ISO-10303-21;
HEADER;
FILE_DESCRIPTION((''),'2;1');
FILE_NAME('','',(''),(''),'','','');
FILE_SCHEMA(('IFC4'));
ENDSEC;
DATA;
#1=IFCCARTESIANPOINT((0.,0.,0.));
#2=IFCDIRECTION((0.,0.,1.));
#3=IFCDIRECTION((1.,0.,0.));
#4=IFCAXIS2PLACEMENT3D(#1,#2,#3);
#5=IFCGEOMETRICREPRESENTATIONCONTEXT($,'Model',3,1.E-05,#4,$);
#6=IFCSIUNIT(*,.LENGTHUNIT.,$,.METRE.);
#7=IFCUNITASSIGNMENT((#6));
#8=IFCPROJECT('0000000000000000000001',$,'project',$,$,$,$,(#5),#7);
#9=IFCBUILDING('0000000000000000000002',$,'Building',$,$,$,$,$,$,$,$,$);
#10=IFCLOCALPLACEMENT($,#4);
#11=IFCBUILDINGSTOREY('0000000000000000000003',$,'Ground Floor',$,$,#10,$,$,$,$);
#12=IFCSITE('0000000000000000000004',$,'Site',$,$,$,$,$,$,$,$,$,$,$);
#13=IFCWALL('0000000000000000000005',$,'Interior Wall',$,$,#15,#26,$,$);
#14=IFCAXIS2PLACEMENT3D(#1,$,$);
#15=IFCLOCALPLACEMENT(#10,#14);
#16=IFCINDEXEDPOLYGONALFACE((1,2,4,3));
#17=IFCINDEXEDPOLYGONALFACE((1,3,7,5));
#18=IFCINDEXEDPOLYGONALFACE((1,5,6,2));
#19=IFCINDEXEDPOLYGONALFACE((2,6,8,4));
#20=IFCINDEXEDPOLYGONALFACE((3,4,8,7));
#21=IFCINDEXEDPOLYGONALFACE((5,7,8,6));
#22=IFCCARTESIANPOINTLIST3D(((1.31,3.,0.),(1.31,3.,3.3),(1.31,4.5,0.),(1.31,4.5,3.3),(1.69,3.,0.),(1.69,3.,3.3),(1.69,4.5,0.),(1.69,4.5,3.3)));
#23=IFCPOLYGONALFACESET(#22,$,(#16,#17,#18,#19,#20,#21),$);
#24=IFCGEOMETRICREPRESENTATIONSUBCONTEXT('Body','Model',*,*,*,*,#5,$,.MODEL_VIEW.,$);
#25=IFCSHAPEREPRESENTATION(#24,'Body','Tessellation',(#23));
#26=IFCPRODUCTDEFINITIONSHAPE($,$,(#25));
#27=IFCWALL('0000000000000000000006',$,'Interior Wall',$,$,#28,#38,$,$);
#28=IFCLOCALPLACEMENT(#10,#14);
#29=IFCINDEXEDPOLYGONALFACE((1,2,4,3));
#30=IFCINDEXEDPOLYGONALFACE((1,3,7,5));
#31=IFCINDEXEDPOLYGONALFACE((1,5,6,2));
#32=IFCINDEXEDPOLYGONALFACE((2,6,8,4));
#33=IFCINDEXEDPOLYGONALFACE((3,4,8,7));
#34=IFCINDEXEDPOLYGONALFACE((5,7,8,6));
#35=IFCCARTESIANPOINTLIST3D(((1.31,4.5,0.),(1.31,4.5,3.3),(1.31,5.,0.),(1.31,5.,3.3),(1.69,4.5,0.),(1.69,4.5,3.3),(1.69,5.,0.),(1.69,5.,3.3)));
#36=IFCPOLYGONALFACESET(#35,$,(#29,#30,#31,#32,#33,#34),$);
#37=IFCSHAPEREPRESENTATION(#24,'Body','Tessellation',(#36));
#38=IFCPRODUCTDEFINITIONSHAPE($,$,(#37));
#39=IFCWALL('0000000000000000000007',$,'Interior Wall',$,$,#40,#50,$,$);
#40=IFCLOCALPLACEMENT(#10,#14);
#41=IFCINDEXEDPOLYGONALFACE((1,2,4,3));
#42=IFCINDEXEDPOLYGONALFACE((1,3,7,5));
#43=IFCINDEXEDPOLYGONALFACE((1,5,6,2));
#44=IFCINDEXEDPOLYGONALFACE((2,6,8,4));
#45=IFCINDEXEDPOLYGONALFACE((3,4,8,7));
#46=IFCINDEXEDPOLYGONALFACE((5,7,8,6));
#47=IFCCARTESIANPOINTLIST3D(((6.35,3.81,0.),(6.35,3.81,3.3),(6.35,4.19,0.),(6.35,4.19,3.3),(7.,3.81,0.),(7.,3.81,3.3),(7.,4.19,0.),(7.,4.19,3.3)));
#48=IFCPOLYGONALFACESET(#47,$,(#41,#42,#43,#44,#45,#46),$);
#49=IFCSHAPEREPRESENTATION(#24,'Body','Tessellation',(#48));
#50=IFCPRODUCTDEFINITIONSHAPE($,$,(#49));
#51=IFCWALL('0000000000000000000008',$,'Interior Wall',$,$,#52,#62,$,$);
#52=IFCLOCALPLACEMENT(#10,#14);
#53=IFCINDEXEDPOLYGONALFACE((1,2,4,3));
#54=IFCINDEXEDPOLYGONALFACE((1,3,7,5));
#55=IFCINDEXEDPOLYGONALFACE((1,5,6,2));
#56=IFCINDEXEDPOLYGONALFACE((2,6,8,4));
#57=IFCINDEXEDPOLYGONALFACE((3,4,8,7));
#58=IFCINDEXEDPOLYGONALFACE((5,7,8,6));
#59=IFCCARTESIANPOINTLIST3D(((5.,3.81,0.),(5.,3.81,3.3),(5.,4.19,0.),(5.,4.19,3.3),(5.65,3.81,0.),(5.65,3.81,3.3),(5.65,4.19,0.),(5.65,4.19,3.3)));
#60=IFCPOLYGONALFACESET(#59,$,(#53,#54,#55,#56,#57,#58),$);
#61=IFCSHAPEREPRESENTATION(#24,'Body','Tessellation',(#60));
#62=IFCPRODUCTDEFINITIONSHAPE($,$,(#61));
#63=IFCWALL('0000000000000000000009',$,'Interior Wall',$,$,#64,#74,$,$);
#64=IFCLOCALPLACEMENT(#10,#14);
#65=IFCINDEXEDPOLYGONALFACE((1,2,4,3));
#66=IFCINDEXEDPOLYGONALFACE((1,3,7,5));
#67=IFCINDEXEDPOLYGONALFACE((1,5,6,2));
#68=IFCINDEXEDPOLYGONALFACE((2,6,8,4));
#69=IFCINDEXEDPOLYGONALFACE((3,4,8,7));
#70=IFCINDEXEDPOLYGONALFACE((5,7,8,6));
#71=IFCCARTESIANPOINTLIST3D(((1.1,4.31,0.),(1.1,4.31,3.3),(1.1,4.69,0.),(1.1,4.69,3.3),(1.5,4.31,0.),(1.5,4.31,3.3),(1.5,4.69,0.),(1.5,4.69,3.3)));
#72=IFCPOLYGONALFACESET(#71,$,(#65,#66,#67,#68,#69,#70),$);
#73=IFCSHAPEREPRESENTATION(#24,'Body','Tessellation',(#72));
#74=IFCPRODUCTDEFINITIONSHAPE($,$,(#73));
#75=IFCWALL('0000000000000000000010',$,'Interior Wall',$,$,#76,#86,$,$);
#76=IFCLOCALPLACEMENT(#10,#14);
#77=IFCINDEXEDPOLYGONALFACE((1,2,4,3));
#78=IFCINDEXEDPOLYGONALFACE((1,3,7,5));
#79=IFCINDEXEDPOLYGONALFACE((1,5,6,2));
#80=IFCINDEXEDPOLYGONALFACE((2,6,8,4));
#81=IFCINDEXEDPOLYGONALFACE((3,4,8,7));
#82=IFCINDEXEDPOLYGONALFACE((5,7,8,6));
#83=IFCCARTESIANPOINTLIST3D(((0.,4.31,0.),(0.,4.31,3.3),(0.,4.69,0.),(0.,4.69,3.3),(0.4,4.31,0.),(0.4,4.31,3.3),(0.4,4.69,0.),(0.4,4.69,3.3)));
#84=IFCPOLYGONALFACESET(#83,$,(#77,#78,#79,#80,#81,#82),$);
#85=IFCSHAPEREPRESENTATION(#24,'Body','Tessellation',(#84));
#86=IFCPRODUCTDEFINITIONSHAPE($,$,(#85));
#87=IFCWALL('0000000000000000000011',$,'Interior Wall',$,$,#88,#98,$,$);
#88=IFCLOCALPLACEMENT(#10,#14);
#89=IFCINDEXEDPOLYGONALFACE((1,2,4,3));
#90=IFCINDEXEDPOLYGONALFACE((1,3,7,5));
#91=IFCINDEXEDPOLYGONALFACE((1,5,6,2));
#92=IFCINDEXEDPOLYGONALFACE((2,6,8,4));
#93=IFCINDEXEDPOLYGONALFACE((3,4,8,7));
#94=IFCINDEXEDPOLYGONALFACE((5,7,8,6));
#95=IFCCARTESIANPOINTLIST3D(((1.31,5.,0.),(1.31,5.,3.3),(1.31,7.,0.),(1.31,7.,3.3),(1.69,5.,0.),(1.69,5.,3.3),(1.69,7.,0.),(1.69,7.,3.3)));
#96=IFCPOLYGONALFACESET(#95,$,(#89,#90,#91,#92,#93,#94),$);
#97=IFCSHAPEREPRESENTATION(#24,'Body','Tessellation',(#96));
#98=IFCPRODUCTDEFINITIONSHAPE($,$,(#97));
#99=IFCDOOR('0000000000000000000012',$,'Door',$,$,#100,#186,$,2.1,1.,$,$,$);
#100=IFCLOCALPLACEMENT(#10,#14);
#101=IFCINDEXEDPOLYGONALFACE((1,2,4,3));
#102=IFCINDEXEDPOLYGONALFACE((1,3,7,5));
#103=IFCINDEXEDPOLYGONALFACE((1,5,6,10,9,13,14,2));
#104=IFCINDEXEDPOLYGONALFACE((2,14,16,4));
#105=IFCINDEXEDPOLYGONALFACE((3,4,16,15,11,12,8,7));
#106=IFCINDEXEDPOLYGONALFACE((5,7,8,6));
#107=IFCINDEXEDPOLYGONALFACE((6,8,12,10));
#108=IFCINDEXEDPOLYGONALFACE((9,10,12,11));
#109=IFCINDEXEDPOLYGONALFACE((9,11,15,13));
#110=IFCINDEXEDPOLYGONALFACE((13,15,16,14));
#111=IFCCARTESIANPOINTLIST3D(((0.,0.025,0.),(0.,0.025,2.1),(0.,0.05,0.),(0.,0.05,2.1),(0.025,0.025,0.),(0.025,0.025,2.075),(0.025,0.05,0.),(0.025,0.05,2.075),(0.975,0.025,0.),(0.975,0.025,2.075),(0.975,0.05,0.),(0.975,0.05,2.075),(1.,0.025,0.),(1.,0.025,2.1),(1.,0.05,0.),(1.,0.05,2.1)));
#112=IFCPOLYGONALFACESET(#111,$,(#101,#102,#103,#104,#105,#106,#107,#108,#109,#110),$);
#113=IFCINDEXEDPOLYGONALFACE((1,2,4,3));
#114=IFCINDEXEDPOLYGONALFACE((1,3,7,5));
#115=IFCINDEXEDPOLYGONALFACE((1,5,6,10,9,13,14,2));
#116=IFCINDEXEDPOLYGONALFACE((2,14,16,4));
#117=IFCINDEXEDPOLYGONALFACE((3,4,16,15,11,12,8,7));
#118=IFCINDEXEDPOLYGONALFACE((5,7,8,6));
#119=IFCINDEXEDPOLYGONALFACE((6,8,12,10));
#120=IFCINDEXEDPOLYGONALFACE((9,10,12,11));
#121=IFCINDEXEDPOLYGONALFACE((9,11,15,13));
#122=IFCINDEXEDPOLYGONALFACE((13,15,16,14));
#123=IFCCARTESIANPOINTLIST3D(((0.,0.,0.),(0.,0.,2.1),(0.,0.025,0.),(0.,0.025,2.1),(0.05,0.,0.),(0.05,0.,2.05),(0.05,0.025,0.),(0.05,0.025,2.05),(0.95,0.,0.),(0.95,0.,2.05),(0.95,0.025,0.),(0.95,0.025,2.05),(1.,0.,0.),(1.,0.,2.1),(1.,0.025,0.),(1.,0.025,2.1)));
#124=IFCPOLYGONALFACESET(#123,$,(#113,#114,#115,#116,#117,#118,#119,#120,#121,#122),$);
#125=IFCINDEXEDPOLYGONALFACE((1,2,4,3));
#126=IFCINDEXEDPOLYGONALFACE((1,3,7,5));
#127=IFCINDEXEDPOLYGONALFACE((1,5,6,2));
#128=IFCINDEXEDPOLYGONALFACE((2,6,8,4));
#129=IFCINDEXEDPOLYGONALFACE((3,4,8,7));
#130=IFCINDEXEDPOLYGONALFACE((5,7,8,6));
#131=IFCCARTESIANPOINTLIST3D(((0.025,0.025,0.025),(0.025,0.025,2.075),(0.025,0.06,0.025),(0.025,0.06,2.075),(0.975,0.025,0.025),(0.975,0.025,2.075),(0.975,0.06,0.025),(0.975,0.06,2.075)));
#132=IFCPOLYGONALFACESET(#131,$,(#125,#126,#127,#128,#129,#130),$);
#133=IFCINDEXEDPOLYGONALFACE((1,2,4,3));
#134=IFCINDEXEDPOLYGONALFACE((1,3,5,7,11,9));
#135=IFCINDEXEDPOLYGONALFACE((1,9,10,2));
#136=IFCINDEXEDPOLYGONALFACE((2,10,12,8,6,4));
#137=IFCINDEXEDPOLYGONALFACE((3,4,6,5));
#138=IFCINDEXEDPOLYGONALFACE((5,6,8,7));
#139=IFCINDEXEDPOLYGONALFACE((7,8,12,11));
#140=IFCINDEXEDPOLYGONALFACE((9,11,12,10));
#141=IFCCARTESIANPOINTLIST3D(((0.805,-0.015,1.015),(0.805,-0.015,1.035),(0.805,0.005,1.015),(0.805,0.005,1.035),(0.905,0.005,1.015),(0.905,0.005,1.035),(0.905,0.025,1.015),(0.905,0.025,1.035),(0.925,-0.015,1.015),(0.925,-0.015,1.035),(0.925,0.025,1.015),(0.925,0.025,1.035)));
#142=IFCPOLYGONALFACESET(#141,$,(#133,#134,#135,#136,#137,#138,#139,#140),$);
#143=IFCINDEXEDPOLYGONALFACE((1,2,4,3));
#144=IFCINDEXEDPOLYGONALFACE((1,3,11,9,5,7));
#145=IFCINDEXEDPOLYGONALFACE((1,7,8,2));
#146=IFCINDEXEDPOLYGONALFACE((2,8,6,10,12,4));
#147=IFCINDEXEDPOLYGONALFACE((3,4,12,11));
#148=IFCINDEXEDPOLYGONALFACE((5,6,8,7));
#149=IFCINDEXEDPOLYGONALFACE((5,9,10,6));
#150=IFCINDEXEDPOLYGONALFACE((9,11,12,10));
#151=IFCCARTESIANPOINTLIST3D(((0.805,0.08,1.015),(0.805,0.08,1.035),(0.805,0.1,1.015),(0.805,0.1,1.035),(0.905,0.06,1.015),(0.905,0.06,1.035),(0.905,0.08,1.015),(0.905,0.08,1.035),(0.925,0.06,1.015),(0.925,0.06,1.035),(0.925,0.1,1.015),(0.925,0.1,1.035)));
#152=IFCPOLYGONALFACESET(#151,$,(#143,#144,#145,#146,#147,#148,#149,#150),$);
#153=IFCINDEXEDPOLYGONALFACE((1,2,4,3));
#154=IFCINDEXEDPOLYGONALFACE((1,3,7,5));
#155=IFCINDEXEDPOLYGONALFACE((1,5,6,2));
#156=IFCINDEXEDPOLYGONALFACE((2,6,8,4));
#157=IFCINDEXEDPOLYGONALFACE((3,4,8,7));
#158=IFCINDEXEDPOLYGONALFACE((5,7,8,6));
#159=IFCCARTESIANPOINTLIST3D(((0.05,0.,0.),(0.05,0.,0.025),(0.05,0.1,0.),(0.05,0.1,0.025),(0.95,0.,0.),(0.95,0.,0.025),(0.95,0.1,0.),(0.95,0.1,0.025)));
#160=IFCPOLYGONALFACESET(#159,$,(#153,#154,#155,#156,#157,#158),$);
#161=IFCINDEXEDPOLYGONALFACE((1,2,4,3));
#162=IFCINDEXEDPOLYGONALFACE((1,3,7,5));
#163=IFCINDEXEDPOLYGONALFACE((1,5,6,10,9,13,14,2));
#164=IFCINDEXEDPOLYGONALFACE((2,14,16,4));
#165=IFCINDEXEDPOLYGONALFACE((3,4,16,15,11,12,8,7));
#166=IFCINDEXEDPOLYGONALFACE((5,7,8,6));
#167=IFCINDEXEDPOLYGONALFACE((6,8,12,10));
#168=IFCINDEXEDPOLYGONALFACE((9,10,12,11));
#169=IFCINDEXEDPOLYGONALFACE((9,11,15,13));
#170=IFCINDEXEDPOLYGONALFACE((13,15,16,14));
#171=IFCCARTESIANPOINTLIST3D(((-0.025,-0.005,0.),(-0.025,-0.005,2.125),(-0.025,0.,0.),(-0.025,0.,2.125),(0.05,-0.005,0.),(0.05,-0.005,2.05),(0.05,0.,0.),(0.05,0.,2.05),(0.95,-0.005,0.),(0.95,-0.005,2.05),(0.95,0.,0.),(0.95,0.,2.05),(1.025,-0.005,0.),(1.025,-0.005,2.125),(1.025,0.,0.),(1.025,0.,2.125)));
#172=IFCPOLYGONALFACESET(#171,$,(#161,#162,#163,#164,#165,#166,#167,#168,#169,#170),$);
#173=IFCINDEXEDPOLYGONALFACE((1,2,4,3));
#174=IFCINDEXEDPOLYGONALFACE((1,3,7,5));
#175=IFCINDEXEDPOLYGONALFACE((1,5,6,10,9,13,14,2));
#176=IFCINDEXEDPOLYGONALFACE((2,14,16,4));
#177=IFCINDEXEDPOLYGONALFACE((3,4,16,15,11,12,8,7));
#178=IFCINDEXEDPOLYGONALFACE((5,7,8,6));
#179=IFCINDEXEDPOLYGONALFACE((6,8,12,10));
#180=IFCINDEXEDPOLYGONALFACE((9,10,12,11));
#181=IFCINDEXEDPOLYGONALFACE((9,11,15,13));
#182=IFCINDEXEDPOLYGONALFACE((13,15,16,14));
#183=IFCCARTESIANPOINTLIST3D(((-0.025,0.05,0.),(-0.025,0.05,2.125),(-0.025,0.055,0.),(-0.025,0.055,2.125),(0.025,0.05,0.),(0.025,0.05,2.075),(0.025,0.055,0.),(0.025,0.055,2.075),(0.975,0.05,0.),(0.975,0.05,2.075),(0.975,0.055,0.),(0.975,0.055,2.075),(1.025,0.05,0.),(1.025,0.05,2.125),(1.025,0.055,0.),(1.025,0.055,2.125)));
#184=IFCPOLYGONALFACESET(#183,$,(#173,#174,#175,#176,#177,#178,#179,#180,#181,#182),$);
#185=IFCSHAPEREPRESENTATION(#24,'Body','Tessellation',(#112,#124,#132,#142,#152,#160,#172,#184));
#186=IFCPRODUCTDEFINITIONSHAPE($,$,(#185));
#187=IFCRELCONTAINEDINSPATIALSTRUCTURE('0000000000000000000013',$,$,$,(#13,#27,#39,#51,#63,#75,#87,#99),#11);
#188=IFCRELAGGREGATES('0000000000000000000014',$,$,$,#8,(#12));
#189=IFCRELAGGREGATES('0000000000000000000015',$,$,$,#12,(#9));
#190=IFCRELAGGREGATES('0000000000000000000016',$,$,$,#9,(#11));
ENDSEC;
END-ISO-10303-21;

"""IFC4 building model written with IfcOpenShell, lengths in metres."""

from ifc_helpers import new_model, si_unit, frame, origin_with_axes, place, context, subcontext, project, spatial, line, indexed_curve, outline, extrude, element, save


model = new_model("IFC4")

# Units and contexts
model_context = context("Model", 3, precision=1e-05, world=origin_with_axes())
body_context = subcontext(model_context, "Body", "Model", "MODEL_VIEW")
ifc_project = project(units=[si_unit("LENGTHUNIT", "METRE")], contexts=[model_context])

# Site, building, storey
site = spatial("IfcSite", under=ifc_project, Name="Site")
building = spatial("IfcBuilding", under=site, Name="Building")
storey_placement = place(None, origin_with_axes())
storey = spatial("IfcBuildingStorey", under=building, at=storey_placement, Name="Ground Floor")

# Walls
wall_1_placement = place(storey_placement, frame((1.5, 4.5, 0.0), z_axis=(0.0, 0.0, 1.0), x_axis=(0.0, -1.0, 0.0)))
element("IfcWall", 1, at=wall_1_placement, inside=storey, Name="Interior Wall", context=body_context, shape_type="SweptSolid", body=[
    extrude(outline(indexed_curve([(0.0, 0.0), (0.0, 0.38), (1.5, 0.38), (1.5, 0.0), (0.0, 0.0)], self_intersect=False)), frame((0.0, -0.19, 0.0), z_axis=(0.0, 0.0, 1.0), x_axis=(1.0, 0.0, 0.0)), (0.0, 0.0, 1.0), 3.3),
])
wall_2_placement = place(storey_placement, frame((1.5, 5.0, 0.0), z_axis=(0.0, 0.0, 1.0), x_axis=(0.0, -1.0, 0.0)))
element("IfcWall", 2, at=wall_2_placement, inside=storey, Name="Interior Wall", context=body_context, shape_type="SweptSolid", body=[
    extrude(outline(indexed_curve([(0.0, 0.0), (0.0, 0.38), (0.5, 0.38), (0.5, 0.0), (0.0, 0.0)], self_intersect=False)), frame((0.0, -0.19, 0.0), z_axis=(0.0, 0.0, 1.0), x_axis=(1.0, 0.0, 0.0)), (0.0, 0.0, 1.0), 3.3),
])
for number, where, z_axis, x_axis, name in (
    (3, (7.0, 4.0, 0.0), (0.0, 0.0, 1.0), (-1.0, 0.0, 0.0), "Interior Wall"),
    (4, (5.65, 4.0, 0.0), (0.0, 0.0, 1.0), (-1.0, 0.0, 0.0), "Interior Wall"),
):
    element("IfcWall", number, at=place(storey_placement, frame(where, z_axis=z_axis, x_axis=x_axis)), inside=storey, Name=name, context=body_context, shape_type="SweptSolid", body=[
        extrude(outline(indexed_curve([(0.0, 0.0), (0.0, 0.38), (0.65, 0.38), (0.65, 0.0), (0.0, 0.0)], self_intersect=False)), frame((0.0, -0.19, 0.0), z_axis=(0.0, 0.0, 1.0), x_axis=(1.0, 0.0, 0.0)), (0.0, 0.0, 1.0), 3.3),
    ])
for number, where, z_axis, x_axis, name in (
    (5, (1.5, 4.5, 0.0), (0.0, 0.0, 1.0), (-1.0, 0.0, 0.0), "Interior Wall"),
    (6, (0.4, 4.5, 0.0), (0.0, 0.0, 1.0), (-1.0, 0.0, 0.0), "Interior Wall"),
):
    element("IfcWall", number, at=place(storey_placement, frame(where, z_axis=z_axis, x_axis=x_axis)), inside=storey, Name=name, context=body_context, shape_type="SweptSolid", body=[
        extrude(outline(indexed_curve([(0.0, 0.0), (0.0, 0.38), (0.4, 0.38), (0.4, 0.0), (0.0, 0.0)], self_intersect=False)), frame((0.0, -0.19, 0.0), z_axis=(0.0, 0.0, 1.0), x_axis=(1.0, 0.0, 0.0)), (0.0, 0.0, 1.0), 3.3),
    ])
wall_3_placement = place(storey_placement, frame((1.5, 5.0, 0.0), z_axis=(0.0, 0.0, 1.0), x_axis=(0.0, 1.0, 0.0)))
element("IfcWall", 7, at=wall_3_placement, inside=storey, Name="Interior Wall", context=body_context, shape_type="SweptSolid", body=[
    extrude(outline(indexed_curve([(0.0, 0.0), (0.0, 0.38), (2.0, 0.38), (2.0, 0.0), (0.0, 0.0)], self_intersect=False)), frame((0.0, -0.19, 0.0), z_axis=(0.0, 0.0, 1.0), x_axis=(1.0, 0.0, 0.0)), (0.0, 0.0, 1.0), 3.3),
])

# Door
door_1_placement = place(storey_placement, origin_with_axes())
element("IfcDoor", 8, at=door_1_placement, inside=storey, Name="Door", OverallHeight=2.1, OverallWidth=1.0, context=body_context, shape_type="SweptSolid", body=[
    extrude(outline(indexed_curve([(0.0, 0.0), (0.0, 2.1), (1.0, 2.1), (1.0, 0.0), (0.975, 0.0), (0.975, 2.075), (0.025, 2.075), (0.025, 0.0)], segments=[line(1, 2, 3, 4, 5, 6, 7, 8, 1)])), frame((0.0, 0.025, 0.0), z_axis=(0.0, -1.0, 0.0), x_axis=(1.0, 0.0, 0.0)), (0.0, 0.0, -1.0), 0.025),
    extrude(outline(indexed_curve([(0.0, 0.0), (0.0, 2.1), (1.0, 2.1), (1.0, 0.0), (0.95, 0.0), (0.95, 2.05), (0.05, 2.05), (0.05, 0.0)], segments=[line(1, 2, 3, 4, 5, 6, 7, 8, 1)])), frame((0.0, 0.0, 0.0), z_axis=(0.0, -1.0, 0.0), x_axis=(1.0, 0.0, 0.0)), (0.0, 0.0, -1.0), 0.025),
    extrude(outline(indexed_curve([(0.0, 0.0), (0.95, 0.0), (0.95, 0.035), (0.0, 0.035)], segments=[line(1, 2, 3, 4, 1)])), frame((0.025, 0.025, 0.025), z_axis=(0.0, 0.0, 1.0), x_axis=(1.0, 0.0, 0.0)), (0.0, 0.0, 1.0), 2.05),
    extrude(outline(indexed_curve([(0.0, 0.0), (0.0, -0.04), (-0.12, -0.04), (-0.12, -0.02), (-0.02, -0.02), (-0.02, 0.0)], segments=[line(1, 2, 3, 4, 5, 6, 1)])), frame((0.925, 0.025, 1.015), z_axis=(0.0, 0.0, 1.0), x_axis=(1.0, 0.0, 0.0)), (0.0, 0.0, 1.0), 0.02),
    extrude(outline(indexed_curve([(0.0, 0.0), (0.0, 0.04), (-0.12, 0.04), (-0.12, 0.02), (-0.02, 0.02), (-0.02, 0.0)], segments=[line(1, 2, 3, 4, 5, 6, 1)])), frame((0.925, 0.06, 1.015), z_axis=(0.0, 0.0, 1.0), x_axis=(1.0, 0.0, 0.0)), (0.0, 0.0, 1.0), 0.02),
    extrude(outline(indexed_curve([(0.0, 0.0), (0.9, 0.0), (0.9, 0.1), (0.0, 0.1)], segments=[line(1, 2, 3, 4, 1)])), frame((0.05, 0.0, 0.0), z_axis=(0.0, 0.0, 1.0), x_axis=(1.0, 0.0, 0.0)), (0.0, 0.0, 1.0), 0.025),
    extrude(outline(indexed_curve([(0.0, 0.0), (0.0, 2.125), (1.05, 2.125), (1.05, 0.0), (0.975, 0.0), (0.975, 2.05), (0.075, 2.05), (0.075, 0.0)], segments=[line(1, 2, 3, 4, 5, 6, 7, 8, 1)])), frame((-0.025, -0.005, 0.0), z_axis=(0.0, -1.0, 0.0), x_axis=(1.0, 0.0, 0.0)), (0.0, 0.0, -1.0), 0.005),
    extrude(outline(indexed_curve([(0.0, 0.0), (0.0, 2.125), (1.05, 2.125), (1.05, 0.0), (1.0, 0.0), (1.0, 2.075), (0.05, 2.075), (0.05, 0.0)], segments=[line(1, 2, 3, 4, 5, 6, 7, 8, 1)])), frame((-0.025, 0.05, 0.0), z_axis=(0.0, -1.0, 0.0), x_axis=(1.0, 0.0, 0.0)), (0.0, 0.0, -1.0), 0.005),
])

save(model, "model.ifc")
